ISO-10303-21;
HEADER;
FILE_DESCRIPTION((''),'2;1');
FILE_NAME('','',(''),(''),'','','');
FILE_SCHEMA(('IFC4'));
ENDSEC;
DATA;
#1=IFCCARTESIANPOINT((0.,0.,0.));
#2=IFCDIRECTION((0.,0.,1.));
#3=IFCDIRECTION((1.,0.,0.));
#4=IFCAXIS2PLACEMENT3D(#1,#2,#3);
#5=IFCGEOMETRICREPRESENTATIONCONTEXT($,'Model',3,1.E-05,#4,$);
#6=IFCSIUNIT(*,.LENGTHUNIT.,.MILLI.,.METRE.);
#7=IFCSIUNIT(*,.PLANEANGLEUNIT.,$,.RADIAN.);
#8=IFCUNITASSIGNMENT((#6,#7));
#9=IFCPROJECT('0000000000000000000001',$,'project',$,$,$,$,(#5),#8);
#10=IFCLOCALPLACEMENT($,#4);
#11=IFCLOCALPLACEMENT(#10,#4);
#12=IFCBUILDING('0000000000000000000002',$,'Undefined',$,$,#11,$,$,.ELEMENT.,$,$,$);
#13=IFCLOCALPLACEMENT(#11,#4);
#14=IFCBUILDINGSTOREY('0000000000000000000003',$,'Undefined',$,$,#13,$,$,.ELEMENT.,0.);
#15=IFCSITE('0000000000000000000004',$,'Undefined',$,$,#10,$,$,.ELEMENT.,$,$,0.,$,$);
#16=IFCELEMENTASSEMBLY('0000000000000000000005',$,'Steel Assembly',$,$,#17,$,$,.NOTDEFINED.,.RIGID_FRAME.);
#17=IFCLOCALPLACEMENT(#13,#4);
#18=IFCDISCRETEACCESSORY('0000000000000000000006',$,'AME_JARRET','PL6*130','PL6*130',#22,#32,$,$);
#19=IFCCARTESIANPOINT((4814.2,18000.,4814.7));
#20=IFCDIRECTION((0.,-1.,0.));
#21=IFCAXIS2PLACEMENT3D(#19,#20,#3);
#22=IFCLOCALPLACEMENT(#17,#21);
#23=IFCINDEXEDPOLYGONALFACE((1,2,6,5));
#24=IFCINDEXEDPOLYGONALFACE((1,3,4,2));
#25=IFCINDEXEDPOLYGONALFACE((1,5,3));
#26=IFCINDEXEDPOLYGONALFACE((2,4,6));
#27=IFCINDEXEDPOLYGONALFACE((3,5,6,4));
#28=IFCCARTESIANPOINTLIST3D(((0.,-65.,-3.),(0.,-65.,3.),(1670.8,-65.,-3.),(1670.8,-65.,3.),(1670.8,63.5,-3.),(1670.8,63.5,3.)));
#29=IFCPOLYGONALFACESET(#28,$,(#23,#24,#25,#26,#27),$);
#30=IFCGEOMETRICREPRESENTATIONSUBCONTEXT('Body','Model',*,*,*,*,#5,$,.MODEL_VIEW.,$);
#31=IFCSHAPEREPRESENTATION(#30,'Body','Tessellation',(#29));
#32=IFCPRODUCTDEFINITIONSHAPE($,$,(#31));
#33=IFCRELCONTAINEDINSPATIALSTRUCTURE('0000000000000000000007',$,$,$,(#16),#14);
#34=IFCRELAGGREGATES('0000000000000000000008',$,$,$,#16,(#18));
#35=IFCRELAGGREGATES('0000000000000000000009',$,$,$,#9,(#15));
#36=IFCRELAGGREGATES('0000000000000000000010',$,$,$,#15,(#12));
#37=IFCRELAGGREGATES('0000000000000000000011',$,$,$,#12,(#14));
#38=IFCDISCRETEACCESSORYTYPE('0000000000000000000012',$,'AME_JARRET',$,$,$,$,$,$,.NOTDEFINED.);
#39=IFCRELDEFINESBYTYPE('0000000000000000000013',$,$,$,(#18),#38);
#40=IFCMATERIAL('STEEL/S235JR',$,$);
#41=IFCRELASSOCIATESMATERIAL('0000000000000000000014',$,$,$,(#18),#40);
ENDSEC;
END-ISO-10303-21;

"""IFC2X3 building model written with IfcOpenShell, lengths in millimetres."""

from ifc_helpers import new_model, si_unit, frame, origin_with_axes, place, context, subcontext, project, spatial, polyline, outline, extrude, clip, halfspace, material, type_object, element, aggregate, save


model = new_model("IFC2X3")

# Units and contexts
model_context = context("Model", 3, precision=1e-05, world=origin_with_axes())
body_context = subcontext(model_context, "Body", "Model", "MODEL_VIEW")
ifc_project = project(units=[si_unit("LENGTHUNIT", "METRE", prefix="MILLI"), si_unit("PLANEANGLEUNIT", "RADIAN")], contexts=[model_context])

# Site, building, storey
site_placement = place(None, origin_with_axes())
site = spatial("IfcSite", under=ifc_project, at=site_placement, Name="Undefined", CompositionType="ELEMENT", RefElevation=0.0)
building_placement = place(site_placement, origin_with_axes())
building = spatial("IfcBuilding", under=site, at=building_placement, Name="Undefined", CompositionType="ELEMENT")
storey_placement = place(building_placement, origin_with_axes())
storey = spatial("IfcBuildingStorey", under=building, at=storey_placement, Name="Undefined", CompositionType="ELEMENT", Elevation=0.0)

# Shared definitions
ifc_material_1 = material(Name="STEEL/S235JR")

# Element assembly, discrete accessory
assembly_1_placement = place(storey_placement, origin_with_axes())
assembly_1 = element("IfcElementAssembly", 1, at=assembly_1_placement, inside=storey, Name="Steel Assembly", AssemblyPlace="NOTDEFINED", PredefinedType="RIGID_FRAME")
discrete_accessory_type_1 = type_object("IfcDiscreteAccessoryType", Name="AME_JARRET")
discrete_accessory_1_placement = place(assembly_1_placement, frame((4814.2, 18000.0, 4814.7), z_axis=(0.0, -1.0, 0.0), x_axis=(1.0, 0.0, 0.0)))
discrete_accessory_1 = element("IfcDiscreteAccessory", 2, at=discrete_accessory_1_placement, type_object=discrete_accessory_type_1, material=ifc_material_1, Name="AME_JARRET", Description="PL6*130", ObjectType="PL6*130", context=body_context, shape_type="Clipping", body=[
    clip(clip(extrude(outline(polyline([(1670.8, -65.0), (0.0, -65.0), (1670.8, 63.5), (1670.8, -65.0)])), frame((0.0, 0.0, -3.0), z_axis=(0.0, 0.0, 1.0), x_axis=(1.0, 0.0, 0.0)), (0.0, 0.0, 1.0), 6.0), halfspace(frame((1670.8, 63.5, -3.0), z_axis=(-0.076696, 0.997054, 0.0), x_axis=(0.0, 0.0, 1.0)), False)), halfspace(frame((1670.8, -65.0, 3.0), z_axis=(1.0, 0.0, 0.0), x_axis=(0.0, 1.0, 0.0)), False)),
])
aggregate(assembly_1, [discrete_accessory_1])

save(model, "model.ifc")
